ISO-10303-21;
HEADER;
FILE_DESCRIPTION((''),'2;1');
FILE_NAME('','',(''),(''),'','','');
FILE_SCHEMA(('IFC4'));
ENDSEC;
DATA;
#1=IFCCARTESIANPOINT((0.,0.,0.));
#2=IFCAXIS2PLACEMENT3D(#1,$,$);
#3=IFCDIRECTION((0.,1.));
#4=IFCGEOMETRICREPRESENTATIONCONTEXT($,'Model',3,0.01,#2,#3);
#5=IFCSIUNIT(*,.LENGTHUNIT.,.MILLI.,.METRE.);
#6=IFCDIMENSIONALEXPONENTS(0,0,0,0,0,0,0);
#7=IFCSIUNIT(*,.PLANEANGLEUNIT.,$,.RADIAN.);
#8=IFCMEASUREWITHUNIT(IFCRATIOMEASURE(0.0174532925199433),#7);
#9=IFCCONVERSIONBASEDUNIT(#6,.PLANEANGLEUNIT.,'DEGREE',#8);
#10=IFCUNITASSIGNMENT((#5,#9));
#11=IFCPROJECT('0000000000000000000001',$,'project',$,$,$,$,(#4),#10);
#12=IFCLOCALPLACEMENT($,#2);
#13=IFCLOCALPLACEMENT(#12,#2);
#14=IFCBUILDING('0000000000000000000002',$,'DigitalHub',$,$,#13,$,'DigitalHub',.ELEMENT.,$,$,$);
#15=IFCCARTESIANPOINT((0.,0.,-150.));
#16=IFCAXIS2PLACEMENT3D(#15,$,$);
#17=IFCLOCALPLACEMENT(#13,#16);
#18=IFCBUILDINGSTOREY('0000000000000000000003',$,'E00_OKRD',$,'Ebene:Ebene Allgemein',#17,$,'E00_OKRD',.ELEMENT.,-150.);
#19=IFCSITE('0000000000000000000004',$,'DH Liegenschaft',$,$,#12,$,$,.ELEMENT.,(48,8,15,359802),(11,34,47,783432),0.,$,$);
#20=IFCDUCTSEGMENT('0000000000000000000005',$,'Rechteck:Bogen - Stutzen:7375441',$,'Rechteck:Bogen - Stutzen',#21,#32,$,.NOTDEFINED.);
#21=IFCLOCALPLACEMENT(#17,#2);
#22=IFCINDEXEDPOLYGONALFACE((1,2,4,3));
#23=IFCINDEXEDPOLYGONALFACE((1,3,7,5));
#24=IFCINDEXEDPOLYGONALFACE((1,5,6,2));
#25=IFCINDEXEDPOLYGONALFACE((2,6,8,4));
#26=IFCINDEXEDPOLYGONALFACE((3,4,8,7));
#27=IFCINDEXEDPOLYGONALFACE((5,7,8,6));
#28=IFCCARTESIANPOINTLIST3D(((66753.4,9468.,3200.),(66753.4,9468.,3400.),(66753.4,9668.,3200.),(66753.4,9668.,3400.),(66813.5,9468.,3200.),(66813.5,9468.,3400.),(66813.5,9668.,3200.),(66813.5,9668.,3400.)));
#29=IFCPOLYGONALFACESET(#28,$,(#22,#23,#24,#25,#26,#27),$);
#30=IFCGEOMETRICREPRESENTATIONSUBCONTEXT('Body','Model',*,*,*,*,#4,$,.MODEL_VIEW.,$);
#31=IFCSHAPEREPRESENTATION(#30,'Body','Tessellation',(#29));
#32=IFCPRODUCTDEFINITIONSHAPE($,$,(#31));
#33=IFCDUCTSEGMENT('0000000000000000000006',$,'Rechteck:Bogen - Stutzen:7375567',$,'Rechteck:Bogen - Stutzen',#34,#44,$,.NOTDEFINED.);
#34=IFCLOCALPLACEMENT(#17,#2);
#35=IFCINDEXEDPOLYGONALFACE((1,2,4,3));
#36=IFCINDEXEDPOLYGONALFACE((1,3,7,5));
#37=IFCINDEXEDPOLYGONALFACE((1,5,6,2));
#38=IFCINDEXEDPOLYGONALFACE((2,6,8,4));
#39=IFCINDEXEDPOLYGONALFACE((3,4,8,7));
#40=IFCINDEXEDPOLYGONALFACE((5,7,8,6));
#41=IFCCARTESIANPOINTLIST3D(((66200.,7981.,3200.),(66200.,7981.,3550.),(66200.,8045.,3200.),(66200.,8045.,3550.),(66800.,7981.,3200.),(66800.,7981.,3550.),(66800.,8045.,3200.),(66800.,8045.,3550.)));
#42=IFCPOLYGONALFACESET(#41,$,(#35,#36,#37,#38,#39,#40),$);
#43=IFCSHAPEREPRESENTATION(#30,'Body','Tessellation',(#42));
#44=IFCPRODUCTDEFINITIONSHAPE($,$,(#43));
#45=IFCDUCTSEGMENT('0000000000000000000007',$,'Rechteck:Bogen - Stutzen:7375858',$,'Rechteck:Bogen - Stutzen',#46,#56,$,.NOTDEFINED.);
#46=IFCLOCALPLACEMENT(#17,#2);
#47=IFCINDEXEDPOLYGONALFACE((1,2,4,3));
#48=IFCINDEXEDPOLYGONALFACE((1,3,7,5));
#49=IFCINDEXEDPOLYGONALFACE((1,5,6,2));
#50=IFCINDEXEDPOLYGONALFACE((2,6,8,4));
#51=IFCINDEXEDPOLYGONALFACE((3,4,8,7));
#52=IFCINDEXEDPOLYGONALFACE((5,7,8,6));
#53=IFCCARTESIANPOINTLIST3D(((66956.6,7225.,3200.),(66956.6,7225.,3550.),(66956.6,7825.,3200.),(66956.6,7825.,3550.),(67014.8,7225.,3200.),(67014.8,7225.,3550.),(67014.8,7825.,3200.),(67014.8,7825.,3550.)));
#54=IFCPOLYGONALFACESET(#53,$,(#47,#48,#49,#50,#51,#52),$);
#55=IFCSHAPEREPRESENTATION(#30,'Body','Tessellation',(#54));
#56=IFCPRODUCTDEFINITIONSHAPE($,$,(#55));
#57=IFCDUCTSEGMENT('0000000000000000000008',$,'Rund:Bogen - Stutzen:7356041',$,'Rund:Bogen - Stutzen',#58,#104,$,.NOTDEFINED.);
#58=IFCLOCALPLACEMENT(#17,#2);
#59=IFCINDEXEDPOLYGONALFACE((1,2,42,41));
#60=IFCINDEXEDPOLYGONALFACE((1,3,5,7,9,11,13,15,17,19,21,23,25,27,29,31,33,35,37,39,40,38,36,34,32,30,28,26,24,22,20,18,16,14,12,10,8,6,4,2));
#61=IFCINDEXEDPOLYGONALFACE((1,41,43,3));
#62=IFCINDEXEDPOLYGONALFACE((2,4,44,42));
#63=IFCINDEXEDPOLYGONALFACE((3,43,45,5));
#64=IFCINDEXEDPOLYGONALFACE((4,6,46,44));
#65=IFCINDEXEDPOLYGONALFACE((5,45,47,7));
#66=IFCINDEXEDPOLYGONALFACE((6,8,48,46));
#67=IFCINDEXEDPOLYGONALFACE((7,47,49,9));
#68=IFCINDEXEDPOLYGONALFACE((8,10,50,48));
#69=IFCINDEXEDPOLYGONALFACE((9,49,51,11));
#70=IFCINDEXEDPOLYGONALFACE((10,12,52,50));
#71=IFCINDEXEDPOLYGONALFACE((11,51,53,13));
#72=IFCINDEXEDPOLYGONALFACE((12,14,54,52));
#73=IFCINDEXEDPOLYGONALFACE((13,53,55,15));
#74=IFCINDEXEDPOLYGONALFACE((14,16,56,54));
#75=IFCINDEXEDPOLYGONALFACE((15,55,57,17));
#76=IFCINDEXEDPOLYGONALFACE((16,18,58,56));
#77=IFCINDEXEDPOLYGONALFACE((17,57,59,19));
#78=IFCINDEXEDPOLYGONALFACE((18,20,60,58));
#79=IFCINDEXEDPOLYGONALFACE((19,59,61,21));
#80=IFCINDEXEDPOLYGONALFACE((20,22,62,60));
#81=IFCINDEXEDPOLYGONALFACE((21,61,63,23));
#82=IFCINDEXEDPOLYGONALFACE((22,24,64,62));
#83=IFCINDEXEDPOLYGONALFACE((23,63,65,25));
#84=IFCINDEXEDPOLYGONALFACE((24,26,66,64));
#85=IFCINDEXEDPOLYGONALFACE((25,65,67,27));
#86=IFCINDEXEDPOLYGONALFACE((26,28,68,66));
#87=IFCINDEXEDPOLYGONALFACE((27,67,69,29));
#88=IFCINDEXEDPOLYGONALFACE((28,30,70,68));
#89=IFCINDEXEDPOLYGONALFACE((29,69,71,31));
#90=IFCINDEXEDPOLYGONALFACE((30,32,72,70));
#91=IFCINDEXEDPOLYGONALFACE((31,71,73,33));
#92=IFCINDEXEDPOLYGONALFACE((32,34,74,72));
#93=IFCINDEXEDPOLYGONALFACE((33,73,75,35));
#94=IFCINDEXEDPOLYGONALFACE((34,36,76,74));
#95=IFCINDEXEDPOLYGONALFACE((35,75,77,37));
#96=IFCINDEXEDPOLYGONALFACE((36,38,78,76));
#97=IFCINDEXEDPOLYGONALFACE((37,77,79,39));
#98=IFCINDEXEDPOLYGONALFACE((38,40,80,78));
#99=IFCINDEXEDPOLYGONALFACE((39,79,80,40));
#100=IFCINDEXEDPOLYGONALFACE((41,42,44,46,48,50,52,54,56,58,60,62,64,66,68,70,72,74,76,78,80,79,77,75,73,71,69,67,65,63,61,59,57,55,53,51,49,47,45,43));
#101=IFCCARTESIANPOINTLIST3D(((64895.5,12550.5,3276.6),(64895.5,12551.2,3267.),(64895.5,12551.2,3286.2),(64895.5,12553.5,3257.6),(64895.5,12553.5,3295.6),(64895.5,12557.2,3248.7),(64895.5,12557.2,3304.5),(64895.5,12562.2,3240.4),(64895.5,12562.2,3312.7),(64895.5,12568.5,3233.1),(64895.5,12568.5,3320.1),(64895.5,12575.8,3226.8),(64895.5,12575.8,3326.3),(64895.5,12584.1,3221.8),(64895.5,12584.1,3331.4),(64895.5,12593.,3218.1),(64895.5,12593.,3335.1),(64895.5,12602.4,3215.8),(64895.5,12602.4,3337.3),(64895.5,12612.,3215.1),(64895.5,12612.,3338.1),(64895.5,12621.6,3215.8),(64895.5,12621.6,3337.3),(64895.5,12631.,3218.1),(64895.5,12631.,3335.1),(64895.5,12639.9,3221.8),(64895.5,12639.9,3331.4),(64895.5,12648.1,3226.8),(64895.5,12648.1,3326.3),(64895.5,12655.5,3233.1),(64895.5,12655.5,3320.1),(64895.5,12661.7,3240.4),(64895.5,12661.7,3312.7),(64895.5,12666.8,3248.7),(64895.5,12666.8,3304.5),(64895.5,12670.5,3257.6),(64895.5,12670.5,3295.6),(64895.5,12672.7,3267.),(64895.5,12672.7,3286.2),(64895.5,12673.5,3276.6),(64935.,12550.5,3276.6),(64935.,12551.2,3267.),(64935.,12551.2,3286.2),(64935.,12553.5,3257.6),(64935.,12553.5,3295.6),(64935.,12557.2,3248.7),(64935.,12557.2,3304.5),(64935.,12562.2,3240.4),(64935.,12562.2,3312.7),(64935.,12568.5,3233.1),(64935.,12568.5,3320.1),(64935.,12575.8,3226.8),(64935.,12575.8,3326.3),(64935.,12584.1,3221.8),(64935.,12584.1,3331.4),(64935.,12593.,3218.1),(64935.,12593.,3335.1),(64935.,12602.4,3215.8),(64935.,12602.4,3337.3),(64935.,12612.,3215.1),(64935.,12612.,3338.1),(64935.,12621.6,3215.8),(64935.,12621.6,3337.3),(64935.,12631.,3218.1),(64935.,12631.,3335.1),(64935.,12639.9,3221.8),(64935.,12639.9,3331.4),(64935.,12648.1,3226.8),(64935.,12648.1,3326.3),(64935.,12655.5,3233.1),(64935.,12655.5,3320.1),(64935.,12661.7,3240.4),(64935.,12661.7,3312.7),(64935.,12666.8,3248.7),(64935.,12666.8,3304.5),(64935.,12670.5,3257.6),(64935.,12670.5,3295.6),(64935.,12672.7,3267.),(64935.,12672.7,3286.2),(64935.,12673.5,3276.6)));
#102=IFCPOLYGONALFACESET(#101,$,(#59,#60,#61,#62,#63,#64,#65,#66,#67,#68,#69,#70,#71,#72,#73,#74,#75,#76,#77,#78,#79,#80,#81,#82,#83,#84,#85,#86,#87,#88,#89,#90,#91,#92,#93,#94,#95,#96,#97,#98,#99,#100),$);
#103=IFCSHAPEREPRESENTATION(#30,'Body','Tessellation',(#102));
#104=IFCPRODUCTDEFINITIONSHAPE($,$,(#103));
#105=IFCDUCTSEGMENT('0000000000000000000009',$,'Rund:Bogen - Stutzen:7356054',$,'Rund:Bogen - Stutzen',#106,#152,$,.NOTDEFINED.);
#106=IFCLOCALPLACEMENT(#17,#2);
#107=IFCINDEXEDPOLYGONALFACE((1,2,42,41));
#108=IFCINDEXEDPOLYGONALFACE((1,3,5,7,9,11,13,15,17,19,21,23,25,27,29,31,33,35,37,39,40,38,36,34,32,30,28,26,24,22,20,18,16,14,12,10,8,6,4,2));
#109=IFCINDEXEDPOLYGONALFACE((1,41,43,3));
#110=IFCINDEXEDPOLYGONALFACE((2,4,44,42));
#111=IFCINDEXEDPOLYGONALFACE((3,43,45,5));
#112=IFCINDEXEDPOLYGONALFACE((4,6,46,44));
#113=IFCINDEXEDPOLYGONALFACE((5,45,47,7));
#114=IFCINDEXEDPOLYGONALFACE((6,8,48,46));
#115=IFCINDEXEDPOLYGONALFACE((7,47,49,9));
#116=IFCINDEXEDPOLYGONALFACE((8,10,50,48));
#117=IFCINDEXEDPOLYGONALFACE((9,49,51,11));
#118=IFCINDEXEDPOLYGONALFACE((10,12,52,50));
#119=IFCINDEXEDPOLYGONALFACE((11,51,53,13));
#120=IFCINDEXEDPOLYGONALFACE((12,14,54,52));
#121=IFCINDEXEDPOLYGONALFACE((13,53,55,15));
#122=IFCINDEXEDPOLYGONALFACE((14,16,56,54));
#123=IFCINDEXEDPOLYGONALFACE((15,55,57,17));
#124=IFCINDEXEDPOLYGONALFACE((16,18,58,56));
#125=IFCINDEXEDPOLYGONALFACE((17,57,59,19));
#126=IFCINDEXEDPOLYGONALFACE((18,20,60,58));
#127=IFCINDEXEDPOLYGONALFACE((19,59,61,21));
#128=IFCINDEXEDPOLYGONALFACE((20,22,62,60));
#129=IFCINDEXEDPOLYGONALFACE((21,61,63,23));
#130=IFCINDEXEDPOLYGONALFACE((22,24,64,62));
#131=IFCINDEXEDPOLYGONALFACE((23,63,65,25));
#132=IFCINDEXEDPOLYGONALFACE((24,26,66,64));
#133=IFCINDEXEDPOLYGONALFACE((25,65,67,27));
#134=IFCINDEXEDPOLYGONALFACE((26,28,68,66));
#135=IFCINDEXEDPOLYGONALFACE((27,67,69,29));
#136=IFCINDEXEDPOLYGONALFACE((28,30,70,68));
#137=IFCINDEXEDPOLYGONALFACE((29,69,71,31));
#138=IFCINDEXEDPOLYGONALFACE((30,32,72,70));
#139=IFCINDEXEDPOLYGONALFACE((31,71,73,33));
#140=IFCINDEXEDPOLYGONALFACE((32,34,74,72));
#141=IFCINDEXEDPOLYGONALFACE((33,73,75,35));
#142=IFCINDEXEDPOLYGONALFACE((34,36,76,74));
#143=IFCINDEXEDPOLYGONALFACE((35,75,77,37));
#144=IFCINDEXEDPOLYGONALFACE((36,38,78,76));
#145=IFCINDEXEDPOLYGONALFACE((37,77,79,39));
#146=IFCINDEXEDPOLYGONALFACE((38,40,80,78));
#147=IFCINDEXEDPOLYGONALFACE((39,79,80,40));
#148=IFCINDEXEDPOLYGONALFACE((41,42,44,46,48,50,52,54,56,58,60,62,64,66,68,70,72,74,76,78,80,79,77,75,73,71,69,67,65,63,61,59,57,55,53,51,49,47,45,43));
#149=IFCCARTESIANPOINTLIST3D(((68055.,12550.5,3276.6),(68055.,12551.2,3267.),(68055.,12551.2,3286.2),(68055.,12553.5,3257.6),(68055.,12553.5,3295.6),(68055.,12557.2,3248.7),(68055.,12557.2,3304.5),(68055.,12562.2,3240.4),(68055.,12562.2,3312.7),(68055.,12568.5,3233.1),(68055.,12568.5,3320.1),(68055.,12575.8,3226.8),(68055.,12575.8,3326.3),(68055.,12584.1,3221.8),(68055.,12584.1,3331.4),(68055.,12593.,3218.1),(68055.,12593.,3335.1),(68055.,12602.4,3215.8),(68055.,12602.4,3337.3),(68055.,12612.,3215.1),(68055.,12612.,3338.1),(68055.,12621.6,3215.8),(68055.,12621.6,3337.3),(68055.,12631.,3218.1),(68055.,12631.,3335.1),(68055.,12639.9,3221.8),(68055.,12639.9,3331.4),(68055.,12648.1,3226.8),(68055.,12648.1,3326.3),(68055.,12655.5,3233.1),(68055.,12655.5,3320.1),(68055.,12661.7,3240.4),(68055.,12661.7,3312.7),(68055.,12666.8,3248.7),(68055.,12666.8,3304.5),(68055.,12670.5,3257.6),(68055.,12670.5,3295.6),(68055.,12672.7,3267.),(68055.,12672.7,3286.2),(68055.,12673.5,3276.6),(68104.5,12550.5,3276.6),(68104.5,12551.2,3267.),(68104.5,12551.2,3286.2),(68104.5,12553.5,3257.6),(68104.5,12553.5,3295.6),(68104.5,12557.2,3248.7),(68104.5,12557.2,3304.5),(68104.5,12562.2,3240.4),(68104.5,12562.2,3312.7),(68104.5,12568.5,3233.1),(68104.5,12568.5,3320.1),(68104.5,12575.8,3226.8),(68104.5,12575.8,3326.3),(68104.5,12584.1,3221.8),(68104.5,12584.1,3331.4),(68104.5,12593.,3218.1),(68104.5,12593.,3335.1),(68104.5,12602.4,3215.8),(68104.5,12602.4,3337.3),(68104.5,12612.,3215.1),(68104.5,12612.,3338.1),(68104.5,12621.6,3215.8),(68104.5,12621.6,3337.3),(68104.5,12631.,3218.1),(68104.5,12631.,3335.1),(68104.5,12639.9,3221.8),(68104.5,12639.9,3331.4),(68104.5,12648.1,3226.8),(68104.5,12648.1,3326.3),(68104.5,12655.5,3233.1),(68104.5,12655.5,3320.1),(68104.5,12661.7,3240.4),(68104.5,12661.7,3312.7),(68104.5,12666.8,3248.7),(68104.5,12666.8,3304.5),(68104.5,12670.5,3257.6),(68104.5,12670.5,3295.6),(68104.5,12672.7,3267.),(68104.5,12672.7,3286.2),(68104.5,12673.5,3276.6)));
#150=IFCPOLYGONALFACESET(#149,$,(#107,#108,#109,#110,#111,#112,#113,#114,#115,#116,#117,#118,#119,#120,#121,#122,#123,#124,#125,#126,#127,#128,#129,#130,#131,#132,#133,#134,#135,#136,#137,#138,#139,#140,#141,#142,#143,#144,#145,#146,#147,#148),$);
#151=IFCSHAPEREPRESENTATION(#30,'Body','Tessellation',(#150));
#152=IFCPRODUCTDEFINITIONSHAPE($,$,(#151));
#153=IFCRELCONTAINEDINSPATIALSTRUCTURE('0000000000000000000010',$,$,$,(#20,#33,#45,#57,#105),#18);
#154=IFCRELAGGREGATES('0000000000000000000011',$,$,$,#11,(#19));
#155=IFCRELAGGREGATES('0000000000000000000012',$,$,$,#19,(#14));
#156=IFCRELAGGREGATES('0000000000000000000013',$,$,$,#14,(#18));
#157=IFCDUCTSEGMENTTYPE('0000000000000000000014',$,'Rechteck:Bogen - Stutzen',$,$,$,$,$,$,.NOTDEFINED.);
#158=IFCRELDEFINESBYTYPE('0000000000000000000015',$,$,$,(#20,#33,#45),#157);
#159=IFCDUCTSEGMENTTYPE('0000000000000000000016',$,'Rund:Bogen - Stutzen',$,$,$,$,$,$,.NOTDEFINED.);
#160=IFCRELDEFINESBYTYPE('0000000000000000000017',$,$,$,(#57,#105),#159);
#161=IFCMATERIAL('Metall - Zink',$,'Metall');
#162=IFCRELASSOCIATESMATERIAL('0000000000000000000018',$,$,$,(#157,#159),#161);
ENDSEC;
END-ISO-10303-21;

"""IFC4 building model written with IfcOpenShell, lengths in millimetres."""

from ifc_helpers import new_model, entity, si_unit, converted_unit, direction, frame, origin, place, context, subcontext, project, spatial, indexed_curve, outline, extrude, material, type_object, element, save


model = new_model("IFC4")

# Units and contexts
model_context = context("Model", 3, precision=0.01, world=origin(), true_north=direction((0.0, 1.0)))
body_context = subcontext(model_context, "Body", "Model", "MODEL_VIEW")
ifc_project = project(units=[si_unit("LENGTHUNIT", "METRE", prefix="MILLI"), converted_unit("PLANEANGLEUNIT", "DEGREE", entity("IfcRatioMeasure", 0.0174532925199433), si_unit("PLANEANGLEUNIT", "RADIAN"), dimensions=[0, 0, 0, 0, 0, 0, 0])], contexts=[model_context])

# Site, building, storey
site_placement = place(None, origin())
site = spatial("IfcSite", under=ifc_project, at=site_placement, Name="DH Liegenschaft", CompositionType="ELEMENT", RefLatitude=(48, 8, 15, 359802), RefLongitude=(11, 34, 47, 783432), RefElevation=0.0)
building_placement = place(site_placement, origin())
building = spatial("IfcBuilding", under=site, at=building_placement, Name="DigitalHub", LongName="DigitalHub", CompositionType="ELEMENT")
storey_placement = place(building_placement, frame((0.0, 0.0, -150.0)))
storey = spatial("IfcBuildingStorey", under=building, at=storey_placement, Name="E00_OKRD", ObjectType="Ebene:Ebene Allgemein", LongName="E00_OKRD", CompositionType="ELEMENT", Elevation=-150.0)

# Duct segments
ifc_material_1 = material(Name="Metall - Zink", Category="Metall")
duct_segment_type_1 = type_object("IfcDuctSegmentType", Name="Rechteck:Bogen - Stutzen", PredefinedType="NOTDEFINED", material=ifc_material_1)
duct_segment_1_placement = place(storey_placement, frame((66753.4, 9468.0, 3200.0)))
element("IfcDuctSegment", 1, at=duct_segment_1_placement, inside=storey, type_object=duct_segment_type_1, Name="Rechteck:Bogen - Stutzen:7375441", ObjectType="Rechteck:Bogen - Stutzen", PredefinedType="NOTDEFINED", context=body_context, shape_type="SweptSolid", body=[
    extrude(outline(indexed_curve([(-30.0, -100.0), (30.0, -100.0), (30.0, 100.0), (-30.0, 100.0), (-30.0, -100.0)], self_intersect=False)), frame((30.0, 100.0, 0.0)), (0.0, 0.0, 1.0), 200.0),
])
duct_segment_2_placement = place(storey_placement, frame((66200.0, 7981.0, 3200.0)))
element("IfcDuctSegment", 2, at=duct_segment_2_placement, inside=storey, type_object=duct_segment_type_1, Name="Rechteck:Bogen - Stutzen:7375567", ObjectType="Rechteck:Bogen - Stutzen", PredefinedType="NOTDEFINED", context=body_context, shape_type="SweptSolid", body=[
    extrude(outline(indexed_curve([(-32.0, -300.0), (32.0, -300.0), (32.0, 300.0), (-32.0, 300.0), (-32.0, -300.0)], self_intersect=False)), frame((300.0, 32.0, 0.0), z_axis=(0.0, 0.0, 1.0), x_axis=(0.0, 1.0, 0.0)), (0.0, 0.0, 1.0), 350.0),
])
duct_segment_3_placement = place(storey_placement, frame((66956.6, 7225.0, 3200.0)))
element("IfcDuctSegment", 3, at=duct_segment_3_placement, inside=storey, type_object=duct_segment_type_1, Name="Rechteck:Bogen - Stutzen:7375858", ObjectType="Rechteck:Bogen - Stutzen", PredefinedType="NOTDEFINED", context=body_context, shape_type="SweptSolid", body=[
    extrude(outline(indexed_curve([(-29.1, -300.0), (29.1, -300.0), (29.1, 300.0), (-29.1, 300.0), (-29.1, -300.0)], self_intersect=False)), frame((29.1, 300.0, 0.0), z_axis=(0.0, 0.0, 1.0), x_axis=(-1.0, 0.0, 0.0)), (0.0, 0.0, 1.0), 350.0),
])
duct_segment_type_2 = type_object("IfcDuctSegmentType", Name="Rund:Bogen - Stutzen", PredefinedType="NOTDEFINED", material=ifc_material_1)
duct_segment_4_placement = place(storey_placement, frame((64895.5, 12548.9, 3213.5)))
element("IfcDuctSegment", 4, at=duct_segment_4_placement, inside=storey, type_object=duct_segment_type_2, Name="Rund:Bogen - Stutzen:7356041", ObjectType="Rund:Bogen - Stutzen", PredefinedType="NOTDEFINED", context=body_context, shape_type="SweptSolid", body=[
    extrude(outline(indexed_curve([(61.5, 0.0), (60.7, 9.6), (58.5, 19.0), (54.8, 27.9), (49.8, 36.1), (43.5, 43.5), (36.1, 49.8), (27.9, 54.8), (19.0, 58.5), (9.6, 60.7), (0.0, 61.5), (-9.6, 60.7), (-19.0, 58.5), (-27.9, 54.8), (-36.1, 49.8), (-43.5, 43.5), (-49.8, 36.1), (-54.8, 27.9), (-58.5, 19.0), (-60.7, 9.6), (-61.5, 0.0), (-60.7, -9.6), (-58.5, -19.0), (-54.8, -27.9), (-49.8, -36.1), (-43.5, -43.5), (-36.1, -49.8), (-27.9, -54.8), (-19.0, -58.5), (-9.6, -60.7), (0.0, -61.5), (9.6, -60.7), (19.0, -58.5), (27.9, -54.8), (36.1, -49.8), (43.5, -43.5), (49.8, -36.1), (54.8, -27.9), (58.5, -19.0), (60.7, -9.6), (61.5, 0.0)], self_intersect=False)), frame((0.0, 63.1, 63.1), z_axis=(1.0, 0.0, 0.0), x_axis=(0.0, 1.0, 0.0)), (0.0, 0.0, 1.0), 39.5),
])
duct_segment_5_placement = place(storey_placement, frame((68055.0, 12548.9, 3213.5)))
element("IfcDuctSegment", 5, at=duct_segment_5_placement, inside=storey, type_object=duct_segment_type_2, Name="Rund:Bogen - Stutzen:7356054", ObjectType="Rund:Bogen - Stutzen", PredefinedType="NOTDEFINED", context=body_context, shape_type="SweptSolid", body=[
    extrude(outline(indexed_curve([(61.5, 0.0), (60.7, 9.6), (58.5, 19.0), (54.8, 27.9), (49.8, 36.1), (43.5, 43.5), (36.1, 49.8), (27.9, 54.8), (19.0, 58.5), (9.6, 60.7), (0.0, 61.5), (-9.6, 60.7), (-19.0, 58.5), (-27.9, 54.8), (-36.1, 49.8), (-43.5, 43.5), (-49.8, 36.1), (-54.8, 27.9), (-58.5, 19.0), (-60.7, 9.6), (-61.5, 0.0), (-60.7, -9.6), (-58.5, -19.0), (-54.8, -27.9), (-49.8, -36.1), (-43.5, -43.5), (-36.1, -49.8), (-27.9, -54.8), (-19.0, -58.5), (-9.6, -60.7), (0.0, -61.5), (9.6, -60.7), (19.0, -58.5), (27.9, -54.8), (36.1, -49.8), (43.5, -43.5), (49.8, -36.1), (54.8, -27.9), (58.5, -19.0), (60.7, -9.6), (61.5, 0.0)], self_intersect=False)), frame((0.0, 63.1, 63.1), z_axis=(1.0, 0.0, 0.0), x_axis=(0.0, -1.0, 0.0)), (0.0, 0.0, 1.0), 49.5),
])

save(model, "model.ifc")
